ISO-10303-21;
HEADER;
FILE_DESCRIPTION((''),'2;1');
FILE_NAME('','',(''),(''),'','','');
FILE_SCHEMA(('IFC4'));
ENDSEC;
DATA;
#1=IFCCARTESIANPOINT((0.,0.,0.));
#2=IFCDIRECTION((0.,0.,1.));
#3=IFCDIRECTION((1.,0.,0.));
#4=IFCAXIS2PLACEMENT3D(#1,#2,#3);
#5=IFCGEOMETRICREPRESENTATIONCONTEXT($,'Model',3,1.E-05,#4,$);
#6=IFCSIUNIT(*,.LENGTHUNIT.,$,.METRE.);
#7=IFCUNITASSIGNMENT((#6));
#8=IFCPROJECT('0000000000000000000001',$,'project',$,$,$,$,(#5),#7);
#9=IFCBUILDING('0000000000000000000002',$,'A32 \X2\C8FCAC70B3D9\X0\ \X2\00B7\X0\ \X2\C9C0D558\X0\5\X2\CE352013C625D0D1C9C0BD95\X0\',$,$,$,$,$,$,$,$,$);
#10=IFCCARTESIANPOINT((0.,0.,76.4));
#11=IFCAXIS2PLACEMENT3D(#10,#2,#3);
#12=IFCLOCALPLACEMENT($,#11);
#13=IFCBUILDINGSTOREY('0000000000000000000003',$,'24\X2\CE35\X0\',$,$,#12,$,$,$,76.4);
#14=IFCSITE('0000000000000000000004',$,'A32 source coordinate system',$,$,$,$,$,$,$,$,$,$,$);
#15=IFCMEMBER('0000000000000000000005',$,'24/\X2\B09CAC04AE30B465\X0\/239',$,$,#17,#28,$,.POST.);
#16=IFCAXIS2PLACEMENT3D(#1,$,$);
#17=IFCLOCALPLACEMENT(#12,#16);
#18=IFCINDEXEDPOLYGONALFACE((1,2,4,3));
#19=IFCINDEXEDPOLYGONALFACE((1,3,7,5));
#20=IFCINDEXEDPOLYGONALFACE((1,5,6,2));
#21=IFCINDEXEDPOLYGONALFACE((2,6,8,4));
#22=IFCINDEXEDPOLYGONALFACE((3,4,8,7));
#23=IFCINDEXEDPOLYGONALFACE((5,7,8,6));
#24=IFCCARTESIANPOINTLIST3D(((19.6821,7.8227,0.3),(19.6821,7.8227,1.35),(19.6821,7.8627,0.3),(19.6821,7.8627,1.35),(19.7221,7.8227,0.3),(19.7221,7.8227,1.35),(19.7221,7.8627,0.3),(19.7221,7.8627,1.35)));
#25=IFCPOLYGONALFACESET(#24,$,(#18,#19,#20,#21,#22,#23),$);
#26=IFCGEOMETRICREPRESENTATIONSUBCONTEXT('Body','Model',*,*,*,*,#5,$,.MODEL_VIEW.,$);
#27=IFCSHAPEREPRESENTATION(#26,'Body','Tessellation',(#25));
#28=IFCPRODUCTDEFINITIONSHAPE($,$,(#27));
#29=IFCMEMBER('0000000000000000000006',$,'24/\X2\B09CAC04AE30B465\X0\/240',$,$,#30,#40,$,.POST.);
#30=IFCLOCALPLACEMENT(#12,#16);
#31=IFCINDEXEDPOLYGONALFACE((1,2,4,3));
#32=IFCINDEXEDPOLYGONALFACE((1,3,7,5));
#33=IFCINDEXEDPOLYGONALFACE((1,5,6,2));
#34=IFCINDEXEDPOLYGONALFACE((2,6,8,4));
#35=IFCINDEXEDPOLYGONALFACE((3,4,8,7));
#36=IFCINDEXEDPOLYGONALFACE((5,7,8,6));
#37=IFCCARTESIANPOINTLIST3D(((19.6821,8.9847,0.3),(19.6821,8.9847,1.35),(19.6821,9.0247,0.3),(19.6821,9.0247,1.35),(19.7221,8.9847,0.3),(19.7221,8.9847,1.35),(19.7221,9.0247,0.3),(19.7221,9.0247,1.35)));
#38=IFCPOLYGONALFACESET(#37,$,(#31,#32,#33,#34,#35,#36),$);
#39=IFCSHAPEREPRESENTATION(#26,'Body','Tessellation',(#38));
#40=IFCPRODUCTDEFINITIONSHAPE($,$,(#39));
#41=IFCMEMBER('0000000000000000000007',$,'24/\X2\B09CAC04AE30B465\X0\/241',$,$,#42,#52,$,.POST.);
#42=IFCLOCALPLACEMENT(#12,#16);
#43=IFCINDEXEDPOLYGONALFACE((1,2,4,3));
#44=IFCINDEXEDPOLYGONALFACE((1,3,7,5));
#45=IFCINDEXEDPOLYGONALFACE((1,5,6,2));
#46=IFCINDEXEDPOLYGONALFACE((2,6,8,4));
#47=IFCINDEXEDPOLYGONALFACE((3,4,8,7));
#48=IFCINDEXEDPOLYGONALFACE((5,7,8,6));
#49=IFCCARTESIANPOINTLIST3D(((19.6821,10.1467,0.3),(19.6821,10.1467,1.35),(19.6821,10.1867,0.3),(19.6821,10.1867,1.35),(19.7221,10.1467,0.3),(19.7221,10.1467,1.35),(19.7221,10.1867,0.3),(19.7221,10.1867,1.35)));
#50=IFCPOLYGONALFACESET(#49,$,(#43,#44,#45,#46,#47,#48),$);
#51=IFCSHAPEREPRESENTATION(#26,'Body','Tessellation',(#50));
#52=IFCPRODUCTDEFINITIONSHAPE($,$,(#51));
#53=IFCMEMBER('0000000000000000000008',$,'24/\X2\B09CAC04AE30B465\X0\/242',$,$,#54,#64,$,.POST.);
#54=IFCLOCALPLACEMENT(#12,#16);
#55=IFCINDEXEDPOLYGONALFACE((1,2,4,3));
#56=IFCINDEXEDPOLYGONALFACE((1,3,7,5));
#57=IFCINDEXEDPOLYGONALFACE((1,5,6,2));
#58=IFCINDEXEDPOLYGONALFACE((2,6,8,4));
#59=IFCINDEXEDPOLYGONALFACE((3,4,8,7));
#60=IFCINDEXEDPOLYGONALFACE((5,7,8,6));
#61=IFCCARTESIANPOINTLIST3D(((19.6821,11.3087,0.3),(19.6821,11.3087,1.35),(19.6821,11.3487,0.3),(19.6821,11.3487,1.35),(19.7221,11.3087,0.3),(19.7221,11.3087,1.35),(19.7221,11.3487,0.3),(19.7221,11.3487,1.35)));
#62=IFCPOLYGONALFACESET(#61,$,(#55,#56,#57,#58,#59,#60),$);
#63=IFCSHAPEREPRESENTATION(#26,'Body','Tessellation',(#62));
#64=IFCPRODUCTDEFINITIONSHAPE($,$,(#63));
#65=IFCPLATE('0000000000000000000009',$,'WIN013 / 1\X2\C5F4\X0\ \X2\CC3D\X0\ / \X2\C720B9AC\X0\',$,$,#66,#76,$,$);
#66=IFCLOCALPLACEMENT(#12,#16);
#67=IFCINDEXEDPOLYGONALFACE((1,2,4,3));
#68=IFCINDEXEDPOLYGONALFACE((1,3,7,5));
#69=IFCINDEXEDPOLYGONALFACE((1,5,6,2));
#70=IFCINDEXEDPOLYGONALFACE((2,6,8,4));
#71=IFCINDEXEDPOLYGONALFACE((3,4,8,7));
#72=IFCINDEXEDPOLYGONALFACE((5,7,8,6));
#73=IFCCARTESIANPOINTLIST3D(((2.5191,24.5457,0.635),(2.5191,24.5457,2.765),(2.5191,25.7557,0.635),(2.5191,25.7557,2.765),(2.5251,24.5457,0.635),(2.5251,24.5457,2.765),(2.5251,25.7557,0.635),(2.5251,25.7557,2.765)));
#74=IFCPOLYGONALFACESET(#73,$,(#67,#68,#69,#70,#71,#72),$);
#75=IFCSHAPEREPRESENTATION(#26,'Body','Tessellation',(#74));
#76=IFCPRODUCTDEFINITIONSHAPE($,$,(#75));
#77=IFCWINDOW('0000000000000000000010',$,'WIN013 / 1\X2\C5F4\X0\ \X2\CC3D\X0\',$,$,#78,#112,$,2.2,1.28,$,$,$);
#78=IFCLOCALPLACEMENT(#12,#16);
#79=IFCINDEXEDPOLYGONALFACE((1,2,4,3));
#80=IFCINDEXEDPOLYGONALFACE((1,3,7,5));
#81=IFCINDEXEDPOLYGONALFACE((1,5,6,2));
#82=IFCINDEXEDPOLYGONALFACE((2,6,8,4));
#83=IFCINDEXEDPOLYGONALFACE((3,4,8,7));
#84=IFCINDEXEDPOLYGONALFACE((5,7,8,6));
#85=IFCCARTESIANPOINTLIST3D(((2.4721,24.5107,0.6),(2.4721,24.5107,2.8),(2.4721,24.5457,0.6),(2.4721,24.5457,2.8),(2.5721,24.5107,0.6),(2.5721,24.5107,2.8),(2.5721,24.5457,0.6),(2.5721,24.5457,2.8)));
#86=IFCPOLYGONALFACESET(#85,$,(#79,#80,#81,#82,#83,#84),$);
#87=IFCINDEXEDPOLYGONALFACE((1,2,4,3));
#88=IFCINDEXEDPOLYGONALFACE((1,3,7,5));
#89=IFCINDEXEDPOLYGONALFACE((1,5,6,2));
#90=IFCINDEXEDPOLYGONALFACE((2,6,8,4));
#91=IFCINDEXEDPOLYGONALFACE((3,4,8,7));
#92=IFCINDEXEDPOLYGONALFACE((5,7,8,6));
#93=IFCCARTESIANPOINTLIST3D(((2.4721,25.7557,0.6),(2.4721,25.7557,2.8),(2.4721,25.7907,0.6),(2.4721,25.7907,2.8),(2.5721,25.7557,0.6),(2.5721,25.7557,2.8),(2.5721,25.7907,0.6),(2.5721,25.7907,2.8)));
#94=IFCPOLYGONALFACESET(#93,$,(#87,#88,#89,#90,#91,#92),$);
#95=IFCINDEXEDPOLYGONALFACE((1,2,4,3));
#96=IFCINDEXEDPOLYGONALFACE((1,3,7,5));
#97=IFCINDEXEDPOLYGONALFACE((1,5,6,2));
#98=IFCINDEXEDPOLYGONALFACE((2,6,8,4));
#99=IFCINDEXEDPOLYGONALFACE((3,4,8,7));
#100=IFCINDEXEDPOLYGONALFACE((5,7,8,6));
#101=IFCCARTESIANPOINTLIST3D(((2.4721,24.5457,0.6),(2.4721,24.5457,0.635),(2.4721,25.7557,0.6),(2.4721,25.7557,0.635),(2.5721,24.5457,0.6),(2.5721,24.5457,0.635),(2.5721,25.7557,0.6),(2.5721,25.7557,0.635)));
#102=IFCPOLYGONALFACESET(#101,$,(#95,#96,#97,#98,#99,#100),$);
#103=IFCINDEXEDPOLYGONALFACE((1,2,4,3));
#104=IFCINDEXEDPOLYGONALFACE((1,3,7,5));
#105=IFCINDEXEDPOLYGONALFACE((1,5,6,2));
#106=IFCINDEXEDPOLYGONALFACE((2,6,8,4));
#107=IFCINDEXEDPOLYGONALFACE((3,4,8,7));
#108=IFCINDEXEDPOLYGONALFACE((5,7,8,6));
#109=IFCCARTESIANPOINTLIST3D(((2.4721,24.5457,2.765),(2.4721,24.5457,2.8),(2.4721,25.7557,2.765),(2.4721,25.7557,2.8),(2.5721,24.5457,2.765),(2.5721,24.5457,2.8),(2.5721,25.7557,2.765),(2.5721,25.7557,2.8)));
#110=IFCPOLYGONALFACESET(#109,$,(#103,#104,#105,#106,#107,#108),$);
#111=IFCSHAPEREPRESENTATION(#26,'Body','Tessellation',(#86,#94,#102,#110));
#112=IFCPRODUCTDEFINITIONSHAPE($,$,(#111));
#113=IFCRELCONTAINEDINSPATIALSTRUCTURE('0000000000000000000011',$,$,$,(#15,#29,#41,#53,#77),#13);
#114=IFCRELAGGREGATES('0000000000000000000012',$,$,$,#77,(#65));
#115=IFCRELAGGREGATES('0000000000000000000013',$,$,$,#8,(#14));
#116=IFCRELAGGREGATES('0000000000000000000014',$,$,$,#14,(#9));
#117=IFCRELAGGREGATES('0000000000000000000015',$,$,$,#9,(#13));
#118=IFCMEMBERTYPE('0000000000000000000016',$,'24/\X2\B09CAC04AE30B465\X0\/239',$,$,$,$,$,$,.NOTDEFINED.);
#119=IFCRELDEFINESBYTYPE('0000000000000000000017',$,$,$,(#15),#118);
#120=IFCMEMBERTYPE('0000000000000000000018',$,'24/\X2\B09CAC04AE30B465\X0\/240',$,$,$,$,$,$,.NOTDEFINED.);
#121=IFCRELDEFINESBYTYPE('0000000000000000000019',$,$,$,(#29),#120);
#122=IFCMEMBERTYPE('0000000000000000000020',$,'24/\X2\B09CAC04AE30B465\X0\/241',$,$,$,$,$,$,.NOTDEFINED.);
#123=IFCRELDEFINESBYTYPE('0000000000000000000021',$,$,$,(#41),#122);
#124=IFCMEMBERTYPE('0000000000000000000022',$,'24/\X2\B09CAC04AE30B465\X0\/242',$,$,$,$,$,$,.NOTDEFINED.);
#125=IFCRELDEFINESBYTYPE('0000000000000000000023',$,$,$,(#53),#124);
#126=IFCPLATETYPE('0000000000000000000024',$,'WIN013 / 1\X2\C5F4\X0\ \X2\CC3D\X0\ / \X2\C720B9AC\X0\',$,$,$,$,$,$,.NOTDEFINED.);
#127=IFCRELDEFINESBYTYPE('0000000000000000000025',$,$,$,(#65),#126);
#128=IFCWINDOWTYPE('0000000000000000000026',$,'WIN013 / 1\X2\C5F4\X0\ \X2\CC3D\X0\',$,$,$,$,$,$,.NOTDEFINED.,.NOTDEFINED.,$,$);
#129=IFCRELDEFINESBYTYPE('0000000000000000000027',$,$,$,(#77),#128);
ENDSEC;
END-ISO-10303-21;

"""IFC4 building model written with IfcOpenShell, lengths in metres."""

from ifc_helpers import new_model, si_unit, frame, origin, origin_with_axes, place, context, subcontext, project, spatial, polyline, outline, extrude, source, transform, mapped, type_object, type_shapes, element, aggregate, save


model = new_model("IFC4")

# Units and contexts
model_context = context("Model", 3, precision=1e-05, world=origin_with_axes())
body_context = subcontext(model_context, "Body", "Model", "MODEL_VIEW")
ifc_project = project(units=[si_unit("LENGTHUNIT", "METRE")], contexts=[model_context])

# Site, building, storey
site = spatial("IfcSite", under=ifc_project, Name="A32 source coordinate system")
building = spatial("IfcBuilding", under=site, Name="A32 주거동 · 지하5층–옥탑지붕")
storey_placement = place(None, frame((0.0, 0.0, 76.4), z_axis=(0.0, 0.0, 1.0), x_axis=(1.0, 0.0, 0.0)))
storey = spatial("IfcBuildingStorey", under=building, at=storey_placement, Name="24층", Elevation=76.4)

# Members
member_type_1 = type_object("IfcMemberType", Name="24/난간기둥/239", PredefinedType="NOTDEFINED")
shared_shape_1 = source(origin(), body_context, "Body", "SweptSolid", [
    extrude(outline(polyline([(19.7221, 7.8227), (19.6821, 7.8227), (19.6821, 7.8627), (19.7221, 7.8627), (19.7221, 7.8227)])), frame((0.0, 0.0, 0.3)), (0.0, 0.0, 1.0), 1.05),
])
type_shapes(member_type_1, [shared_shape_1])
member_1_placement = place(storey_placement, origin_with_axes())
element("IfcMember", 1, at=member_1_placement, inside=storey, type_object=member_type_1, Name="24/난간기둥/239", PredefinedType="POST", context=body_context, shape_type="MappedRepresentation", body=[
    mapped(shared_shape_1, transform((0.0, 0.0, 0.0), scale=1.0)),
])
member_type_2 = type_object("IfcMemberType", Name="24/난간기둥/240", PredefinedType="NOTDEFINED")
shared_shape_2 = source(origin(), body_context, "Body", "SweptSolid", [
    extrude(outline(polyline([(19.7221, 8.9847), (19.6821, 8.9847), (19.6821, 9.0247), (19.7221, 9.0247), (19.7221, 8.9847)])), frame((0.0, 0.0, 0.3)), (0.0, 0.0, 1.0), 1.05),
])
type_shapes(member_type_2, [shared_shape_2])
member_2_placement = place(storey_placement, origin_with_axes())
element("IfcMember", 2, at=member_2_placement, inside=storey, type_object=member_type_2, Name="24/난간기둥/240", PredefinedType="POST", context=body_context, shape_type="MappedRepresentation", body=[
    mapped(shared_shape_2, transform((0.0, 0.0, 0.0), scale=1.0)),
])
member_type_3 = type_object("IfcMemberType", Name="24/난간기둥/241", PredefinedType="NOTDEFINED")
shared_shape_3 = source(origin(), body_context, "Body", "SweptSolid", [
    extrude(outline(polyline([(19.7221, 10.1467), (19.6821, 10.1467), (19.6821, 10.1867), (19.7221, 10.1867), (19.7221, 10.1467)])), frame((0.0, 0.0, 0.3)), (0.0, 0.0, 1.0), 1.05),
])
type_shapes(member_type_3, [shared_shape_3])
member_3_placement = place(storey_placement, origin_with_axes())
element("IfcMember", 3, at=member_3_placement, inside=storey, type_object=member_type_3, Name="24/난간기둥/241", PredefinedType="POST", context=body_context, shape_type="MappedRepresentation", body=[
    mapped(shared_shape_3, transform((0.0, 0.0, 0.0), scale=1.0)),
])
member_type_4 = type_object("IfcMemberType", Name="24/난간기둥/242", PredefinedType="NOTDEFINED")
shared_shape_4 = source(origin(), body_context, "Body", "SweptSolid", [
    extrude(outline(polyline([(19.7221, 11.3087), (19.6821, 11.3087), (19.6821, 11.3487), (19.7221, 11.3487), (19.7221, 11.3087)])), frame((0.0, 0.0, 0.3)), (0.0, 0.0, 1.0), 1.05),
])
type_shapes(member_type_4, [shared_shape_4])
member_4_placement = place(storey_placement, origin_with_axes())
element("IfcMember", 4, at=member_4_placement, inside=storey, type_object=member_type_4, Name="24/난간기둥/242", PredefinedType="POST", context=body_context, shape_type="MappedRepresentation", body=[
    mapped(shared_shape_4, transform((0.0, 0.0, 0.0), scale=1.0)),
])

# Plate
plate_type_1 = type_object("IfcPlateType", Name="WIN013 / 1열 창 / 유리", PredefinedType="NOTDEFINED")
shared_shape_5 = source(origin(), body_context, "Body", "SweptSolid", [
    extrude(outline(polyline([(2.5191, 24.5457), (2.5191, 25.7557), (2.5251, 25.7557), (2.5251, 24.5457), (2.5191, 24.5457)])), frame((0.0, 0.0, 0.635)), (0.0, 0.0, 1.0), 2.13),
])
type_shapes(plate_type_1, [shared_shape_5])
window_1_placement = place(storey_placement, origin_with_axes())
plate_1_placement = place(window_1_placement, origin_with_axes())
plate_1 = element("IfcPlate", 5, at=plate_1_placement, type_object=plate_type_1, Name="WIN013 / 1열 창 / 유리", context=body_context, shape_type="MappedRepresentation", body=[
    mapped(shared_shape_5, transform((0.0, 0.0, 0.0), scale=1.0)),
])

# Window
window_type_1 = type_object("IfcWindowType", Name="WIN013 / 1열 창", PartitioningType="NOTDEFINED", PredefinedType="NOTDEFINED")
shared_shape_6 = source(origin(), body_context, "Body", "SweptSolid", [
    extrude(outline(polyline([(2.4721, 24.5107), (2.4721, 24.5457), (2.5721, 24.5457), (2.5721, 24.5107), (2.4721, 24.5107)])), frame((0.0, 0.0, 0.6)), (0.0, 0.0, 1.0), 2.2),
    extrude(outline(polyline([(2.4721, 25.7557), (2.4721, 25.7907), (2.5721, 25.7907), (2.5721, 25.7557), (2.4721, 25.7557)])), frame((0.0, 0.0, 0.6)), (0.0, 0.0, 1.0), 2.2),
    extrude(outline(polyline([(2.4721, 24.5457), (2.4721, 25.7557), (2.5721, 25.7557), (2.5721, 24.5457), (2.4721, 24.5457)])), frame((0.0, 0.0, 0.6)), (0.0, 0.0, 1.0), 0.035),
    extrude(outline(polyline([(2.4721, 24.5457), (2.4721, 25.7557), (2.5721, 25.7557), (2.5721, 24.5457), (2.4721, 24.5457)])), frame((0.0, 0.0, 2.765)), (0.0, 0.0, 1.0), 0.035),
])
type_shapes(window_type_1, [shared_shape_6])
window_1 = element("IfcWindow", 6, at=window_1_placement, inside=storey, type_object=window_type_1, Name="WIN013 / 1열 창", OverallHeight=2.2, OverallWidth=1.28, context=body_context, shape_type="MappedRepresentation", body=[
    mapped(shared_shape_6, transform((0.0, 0.0, 0.0), scale=1.0)),
])
aggregate(window_1, [plate_1])

save(model, "model.ifc")
